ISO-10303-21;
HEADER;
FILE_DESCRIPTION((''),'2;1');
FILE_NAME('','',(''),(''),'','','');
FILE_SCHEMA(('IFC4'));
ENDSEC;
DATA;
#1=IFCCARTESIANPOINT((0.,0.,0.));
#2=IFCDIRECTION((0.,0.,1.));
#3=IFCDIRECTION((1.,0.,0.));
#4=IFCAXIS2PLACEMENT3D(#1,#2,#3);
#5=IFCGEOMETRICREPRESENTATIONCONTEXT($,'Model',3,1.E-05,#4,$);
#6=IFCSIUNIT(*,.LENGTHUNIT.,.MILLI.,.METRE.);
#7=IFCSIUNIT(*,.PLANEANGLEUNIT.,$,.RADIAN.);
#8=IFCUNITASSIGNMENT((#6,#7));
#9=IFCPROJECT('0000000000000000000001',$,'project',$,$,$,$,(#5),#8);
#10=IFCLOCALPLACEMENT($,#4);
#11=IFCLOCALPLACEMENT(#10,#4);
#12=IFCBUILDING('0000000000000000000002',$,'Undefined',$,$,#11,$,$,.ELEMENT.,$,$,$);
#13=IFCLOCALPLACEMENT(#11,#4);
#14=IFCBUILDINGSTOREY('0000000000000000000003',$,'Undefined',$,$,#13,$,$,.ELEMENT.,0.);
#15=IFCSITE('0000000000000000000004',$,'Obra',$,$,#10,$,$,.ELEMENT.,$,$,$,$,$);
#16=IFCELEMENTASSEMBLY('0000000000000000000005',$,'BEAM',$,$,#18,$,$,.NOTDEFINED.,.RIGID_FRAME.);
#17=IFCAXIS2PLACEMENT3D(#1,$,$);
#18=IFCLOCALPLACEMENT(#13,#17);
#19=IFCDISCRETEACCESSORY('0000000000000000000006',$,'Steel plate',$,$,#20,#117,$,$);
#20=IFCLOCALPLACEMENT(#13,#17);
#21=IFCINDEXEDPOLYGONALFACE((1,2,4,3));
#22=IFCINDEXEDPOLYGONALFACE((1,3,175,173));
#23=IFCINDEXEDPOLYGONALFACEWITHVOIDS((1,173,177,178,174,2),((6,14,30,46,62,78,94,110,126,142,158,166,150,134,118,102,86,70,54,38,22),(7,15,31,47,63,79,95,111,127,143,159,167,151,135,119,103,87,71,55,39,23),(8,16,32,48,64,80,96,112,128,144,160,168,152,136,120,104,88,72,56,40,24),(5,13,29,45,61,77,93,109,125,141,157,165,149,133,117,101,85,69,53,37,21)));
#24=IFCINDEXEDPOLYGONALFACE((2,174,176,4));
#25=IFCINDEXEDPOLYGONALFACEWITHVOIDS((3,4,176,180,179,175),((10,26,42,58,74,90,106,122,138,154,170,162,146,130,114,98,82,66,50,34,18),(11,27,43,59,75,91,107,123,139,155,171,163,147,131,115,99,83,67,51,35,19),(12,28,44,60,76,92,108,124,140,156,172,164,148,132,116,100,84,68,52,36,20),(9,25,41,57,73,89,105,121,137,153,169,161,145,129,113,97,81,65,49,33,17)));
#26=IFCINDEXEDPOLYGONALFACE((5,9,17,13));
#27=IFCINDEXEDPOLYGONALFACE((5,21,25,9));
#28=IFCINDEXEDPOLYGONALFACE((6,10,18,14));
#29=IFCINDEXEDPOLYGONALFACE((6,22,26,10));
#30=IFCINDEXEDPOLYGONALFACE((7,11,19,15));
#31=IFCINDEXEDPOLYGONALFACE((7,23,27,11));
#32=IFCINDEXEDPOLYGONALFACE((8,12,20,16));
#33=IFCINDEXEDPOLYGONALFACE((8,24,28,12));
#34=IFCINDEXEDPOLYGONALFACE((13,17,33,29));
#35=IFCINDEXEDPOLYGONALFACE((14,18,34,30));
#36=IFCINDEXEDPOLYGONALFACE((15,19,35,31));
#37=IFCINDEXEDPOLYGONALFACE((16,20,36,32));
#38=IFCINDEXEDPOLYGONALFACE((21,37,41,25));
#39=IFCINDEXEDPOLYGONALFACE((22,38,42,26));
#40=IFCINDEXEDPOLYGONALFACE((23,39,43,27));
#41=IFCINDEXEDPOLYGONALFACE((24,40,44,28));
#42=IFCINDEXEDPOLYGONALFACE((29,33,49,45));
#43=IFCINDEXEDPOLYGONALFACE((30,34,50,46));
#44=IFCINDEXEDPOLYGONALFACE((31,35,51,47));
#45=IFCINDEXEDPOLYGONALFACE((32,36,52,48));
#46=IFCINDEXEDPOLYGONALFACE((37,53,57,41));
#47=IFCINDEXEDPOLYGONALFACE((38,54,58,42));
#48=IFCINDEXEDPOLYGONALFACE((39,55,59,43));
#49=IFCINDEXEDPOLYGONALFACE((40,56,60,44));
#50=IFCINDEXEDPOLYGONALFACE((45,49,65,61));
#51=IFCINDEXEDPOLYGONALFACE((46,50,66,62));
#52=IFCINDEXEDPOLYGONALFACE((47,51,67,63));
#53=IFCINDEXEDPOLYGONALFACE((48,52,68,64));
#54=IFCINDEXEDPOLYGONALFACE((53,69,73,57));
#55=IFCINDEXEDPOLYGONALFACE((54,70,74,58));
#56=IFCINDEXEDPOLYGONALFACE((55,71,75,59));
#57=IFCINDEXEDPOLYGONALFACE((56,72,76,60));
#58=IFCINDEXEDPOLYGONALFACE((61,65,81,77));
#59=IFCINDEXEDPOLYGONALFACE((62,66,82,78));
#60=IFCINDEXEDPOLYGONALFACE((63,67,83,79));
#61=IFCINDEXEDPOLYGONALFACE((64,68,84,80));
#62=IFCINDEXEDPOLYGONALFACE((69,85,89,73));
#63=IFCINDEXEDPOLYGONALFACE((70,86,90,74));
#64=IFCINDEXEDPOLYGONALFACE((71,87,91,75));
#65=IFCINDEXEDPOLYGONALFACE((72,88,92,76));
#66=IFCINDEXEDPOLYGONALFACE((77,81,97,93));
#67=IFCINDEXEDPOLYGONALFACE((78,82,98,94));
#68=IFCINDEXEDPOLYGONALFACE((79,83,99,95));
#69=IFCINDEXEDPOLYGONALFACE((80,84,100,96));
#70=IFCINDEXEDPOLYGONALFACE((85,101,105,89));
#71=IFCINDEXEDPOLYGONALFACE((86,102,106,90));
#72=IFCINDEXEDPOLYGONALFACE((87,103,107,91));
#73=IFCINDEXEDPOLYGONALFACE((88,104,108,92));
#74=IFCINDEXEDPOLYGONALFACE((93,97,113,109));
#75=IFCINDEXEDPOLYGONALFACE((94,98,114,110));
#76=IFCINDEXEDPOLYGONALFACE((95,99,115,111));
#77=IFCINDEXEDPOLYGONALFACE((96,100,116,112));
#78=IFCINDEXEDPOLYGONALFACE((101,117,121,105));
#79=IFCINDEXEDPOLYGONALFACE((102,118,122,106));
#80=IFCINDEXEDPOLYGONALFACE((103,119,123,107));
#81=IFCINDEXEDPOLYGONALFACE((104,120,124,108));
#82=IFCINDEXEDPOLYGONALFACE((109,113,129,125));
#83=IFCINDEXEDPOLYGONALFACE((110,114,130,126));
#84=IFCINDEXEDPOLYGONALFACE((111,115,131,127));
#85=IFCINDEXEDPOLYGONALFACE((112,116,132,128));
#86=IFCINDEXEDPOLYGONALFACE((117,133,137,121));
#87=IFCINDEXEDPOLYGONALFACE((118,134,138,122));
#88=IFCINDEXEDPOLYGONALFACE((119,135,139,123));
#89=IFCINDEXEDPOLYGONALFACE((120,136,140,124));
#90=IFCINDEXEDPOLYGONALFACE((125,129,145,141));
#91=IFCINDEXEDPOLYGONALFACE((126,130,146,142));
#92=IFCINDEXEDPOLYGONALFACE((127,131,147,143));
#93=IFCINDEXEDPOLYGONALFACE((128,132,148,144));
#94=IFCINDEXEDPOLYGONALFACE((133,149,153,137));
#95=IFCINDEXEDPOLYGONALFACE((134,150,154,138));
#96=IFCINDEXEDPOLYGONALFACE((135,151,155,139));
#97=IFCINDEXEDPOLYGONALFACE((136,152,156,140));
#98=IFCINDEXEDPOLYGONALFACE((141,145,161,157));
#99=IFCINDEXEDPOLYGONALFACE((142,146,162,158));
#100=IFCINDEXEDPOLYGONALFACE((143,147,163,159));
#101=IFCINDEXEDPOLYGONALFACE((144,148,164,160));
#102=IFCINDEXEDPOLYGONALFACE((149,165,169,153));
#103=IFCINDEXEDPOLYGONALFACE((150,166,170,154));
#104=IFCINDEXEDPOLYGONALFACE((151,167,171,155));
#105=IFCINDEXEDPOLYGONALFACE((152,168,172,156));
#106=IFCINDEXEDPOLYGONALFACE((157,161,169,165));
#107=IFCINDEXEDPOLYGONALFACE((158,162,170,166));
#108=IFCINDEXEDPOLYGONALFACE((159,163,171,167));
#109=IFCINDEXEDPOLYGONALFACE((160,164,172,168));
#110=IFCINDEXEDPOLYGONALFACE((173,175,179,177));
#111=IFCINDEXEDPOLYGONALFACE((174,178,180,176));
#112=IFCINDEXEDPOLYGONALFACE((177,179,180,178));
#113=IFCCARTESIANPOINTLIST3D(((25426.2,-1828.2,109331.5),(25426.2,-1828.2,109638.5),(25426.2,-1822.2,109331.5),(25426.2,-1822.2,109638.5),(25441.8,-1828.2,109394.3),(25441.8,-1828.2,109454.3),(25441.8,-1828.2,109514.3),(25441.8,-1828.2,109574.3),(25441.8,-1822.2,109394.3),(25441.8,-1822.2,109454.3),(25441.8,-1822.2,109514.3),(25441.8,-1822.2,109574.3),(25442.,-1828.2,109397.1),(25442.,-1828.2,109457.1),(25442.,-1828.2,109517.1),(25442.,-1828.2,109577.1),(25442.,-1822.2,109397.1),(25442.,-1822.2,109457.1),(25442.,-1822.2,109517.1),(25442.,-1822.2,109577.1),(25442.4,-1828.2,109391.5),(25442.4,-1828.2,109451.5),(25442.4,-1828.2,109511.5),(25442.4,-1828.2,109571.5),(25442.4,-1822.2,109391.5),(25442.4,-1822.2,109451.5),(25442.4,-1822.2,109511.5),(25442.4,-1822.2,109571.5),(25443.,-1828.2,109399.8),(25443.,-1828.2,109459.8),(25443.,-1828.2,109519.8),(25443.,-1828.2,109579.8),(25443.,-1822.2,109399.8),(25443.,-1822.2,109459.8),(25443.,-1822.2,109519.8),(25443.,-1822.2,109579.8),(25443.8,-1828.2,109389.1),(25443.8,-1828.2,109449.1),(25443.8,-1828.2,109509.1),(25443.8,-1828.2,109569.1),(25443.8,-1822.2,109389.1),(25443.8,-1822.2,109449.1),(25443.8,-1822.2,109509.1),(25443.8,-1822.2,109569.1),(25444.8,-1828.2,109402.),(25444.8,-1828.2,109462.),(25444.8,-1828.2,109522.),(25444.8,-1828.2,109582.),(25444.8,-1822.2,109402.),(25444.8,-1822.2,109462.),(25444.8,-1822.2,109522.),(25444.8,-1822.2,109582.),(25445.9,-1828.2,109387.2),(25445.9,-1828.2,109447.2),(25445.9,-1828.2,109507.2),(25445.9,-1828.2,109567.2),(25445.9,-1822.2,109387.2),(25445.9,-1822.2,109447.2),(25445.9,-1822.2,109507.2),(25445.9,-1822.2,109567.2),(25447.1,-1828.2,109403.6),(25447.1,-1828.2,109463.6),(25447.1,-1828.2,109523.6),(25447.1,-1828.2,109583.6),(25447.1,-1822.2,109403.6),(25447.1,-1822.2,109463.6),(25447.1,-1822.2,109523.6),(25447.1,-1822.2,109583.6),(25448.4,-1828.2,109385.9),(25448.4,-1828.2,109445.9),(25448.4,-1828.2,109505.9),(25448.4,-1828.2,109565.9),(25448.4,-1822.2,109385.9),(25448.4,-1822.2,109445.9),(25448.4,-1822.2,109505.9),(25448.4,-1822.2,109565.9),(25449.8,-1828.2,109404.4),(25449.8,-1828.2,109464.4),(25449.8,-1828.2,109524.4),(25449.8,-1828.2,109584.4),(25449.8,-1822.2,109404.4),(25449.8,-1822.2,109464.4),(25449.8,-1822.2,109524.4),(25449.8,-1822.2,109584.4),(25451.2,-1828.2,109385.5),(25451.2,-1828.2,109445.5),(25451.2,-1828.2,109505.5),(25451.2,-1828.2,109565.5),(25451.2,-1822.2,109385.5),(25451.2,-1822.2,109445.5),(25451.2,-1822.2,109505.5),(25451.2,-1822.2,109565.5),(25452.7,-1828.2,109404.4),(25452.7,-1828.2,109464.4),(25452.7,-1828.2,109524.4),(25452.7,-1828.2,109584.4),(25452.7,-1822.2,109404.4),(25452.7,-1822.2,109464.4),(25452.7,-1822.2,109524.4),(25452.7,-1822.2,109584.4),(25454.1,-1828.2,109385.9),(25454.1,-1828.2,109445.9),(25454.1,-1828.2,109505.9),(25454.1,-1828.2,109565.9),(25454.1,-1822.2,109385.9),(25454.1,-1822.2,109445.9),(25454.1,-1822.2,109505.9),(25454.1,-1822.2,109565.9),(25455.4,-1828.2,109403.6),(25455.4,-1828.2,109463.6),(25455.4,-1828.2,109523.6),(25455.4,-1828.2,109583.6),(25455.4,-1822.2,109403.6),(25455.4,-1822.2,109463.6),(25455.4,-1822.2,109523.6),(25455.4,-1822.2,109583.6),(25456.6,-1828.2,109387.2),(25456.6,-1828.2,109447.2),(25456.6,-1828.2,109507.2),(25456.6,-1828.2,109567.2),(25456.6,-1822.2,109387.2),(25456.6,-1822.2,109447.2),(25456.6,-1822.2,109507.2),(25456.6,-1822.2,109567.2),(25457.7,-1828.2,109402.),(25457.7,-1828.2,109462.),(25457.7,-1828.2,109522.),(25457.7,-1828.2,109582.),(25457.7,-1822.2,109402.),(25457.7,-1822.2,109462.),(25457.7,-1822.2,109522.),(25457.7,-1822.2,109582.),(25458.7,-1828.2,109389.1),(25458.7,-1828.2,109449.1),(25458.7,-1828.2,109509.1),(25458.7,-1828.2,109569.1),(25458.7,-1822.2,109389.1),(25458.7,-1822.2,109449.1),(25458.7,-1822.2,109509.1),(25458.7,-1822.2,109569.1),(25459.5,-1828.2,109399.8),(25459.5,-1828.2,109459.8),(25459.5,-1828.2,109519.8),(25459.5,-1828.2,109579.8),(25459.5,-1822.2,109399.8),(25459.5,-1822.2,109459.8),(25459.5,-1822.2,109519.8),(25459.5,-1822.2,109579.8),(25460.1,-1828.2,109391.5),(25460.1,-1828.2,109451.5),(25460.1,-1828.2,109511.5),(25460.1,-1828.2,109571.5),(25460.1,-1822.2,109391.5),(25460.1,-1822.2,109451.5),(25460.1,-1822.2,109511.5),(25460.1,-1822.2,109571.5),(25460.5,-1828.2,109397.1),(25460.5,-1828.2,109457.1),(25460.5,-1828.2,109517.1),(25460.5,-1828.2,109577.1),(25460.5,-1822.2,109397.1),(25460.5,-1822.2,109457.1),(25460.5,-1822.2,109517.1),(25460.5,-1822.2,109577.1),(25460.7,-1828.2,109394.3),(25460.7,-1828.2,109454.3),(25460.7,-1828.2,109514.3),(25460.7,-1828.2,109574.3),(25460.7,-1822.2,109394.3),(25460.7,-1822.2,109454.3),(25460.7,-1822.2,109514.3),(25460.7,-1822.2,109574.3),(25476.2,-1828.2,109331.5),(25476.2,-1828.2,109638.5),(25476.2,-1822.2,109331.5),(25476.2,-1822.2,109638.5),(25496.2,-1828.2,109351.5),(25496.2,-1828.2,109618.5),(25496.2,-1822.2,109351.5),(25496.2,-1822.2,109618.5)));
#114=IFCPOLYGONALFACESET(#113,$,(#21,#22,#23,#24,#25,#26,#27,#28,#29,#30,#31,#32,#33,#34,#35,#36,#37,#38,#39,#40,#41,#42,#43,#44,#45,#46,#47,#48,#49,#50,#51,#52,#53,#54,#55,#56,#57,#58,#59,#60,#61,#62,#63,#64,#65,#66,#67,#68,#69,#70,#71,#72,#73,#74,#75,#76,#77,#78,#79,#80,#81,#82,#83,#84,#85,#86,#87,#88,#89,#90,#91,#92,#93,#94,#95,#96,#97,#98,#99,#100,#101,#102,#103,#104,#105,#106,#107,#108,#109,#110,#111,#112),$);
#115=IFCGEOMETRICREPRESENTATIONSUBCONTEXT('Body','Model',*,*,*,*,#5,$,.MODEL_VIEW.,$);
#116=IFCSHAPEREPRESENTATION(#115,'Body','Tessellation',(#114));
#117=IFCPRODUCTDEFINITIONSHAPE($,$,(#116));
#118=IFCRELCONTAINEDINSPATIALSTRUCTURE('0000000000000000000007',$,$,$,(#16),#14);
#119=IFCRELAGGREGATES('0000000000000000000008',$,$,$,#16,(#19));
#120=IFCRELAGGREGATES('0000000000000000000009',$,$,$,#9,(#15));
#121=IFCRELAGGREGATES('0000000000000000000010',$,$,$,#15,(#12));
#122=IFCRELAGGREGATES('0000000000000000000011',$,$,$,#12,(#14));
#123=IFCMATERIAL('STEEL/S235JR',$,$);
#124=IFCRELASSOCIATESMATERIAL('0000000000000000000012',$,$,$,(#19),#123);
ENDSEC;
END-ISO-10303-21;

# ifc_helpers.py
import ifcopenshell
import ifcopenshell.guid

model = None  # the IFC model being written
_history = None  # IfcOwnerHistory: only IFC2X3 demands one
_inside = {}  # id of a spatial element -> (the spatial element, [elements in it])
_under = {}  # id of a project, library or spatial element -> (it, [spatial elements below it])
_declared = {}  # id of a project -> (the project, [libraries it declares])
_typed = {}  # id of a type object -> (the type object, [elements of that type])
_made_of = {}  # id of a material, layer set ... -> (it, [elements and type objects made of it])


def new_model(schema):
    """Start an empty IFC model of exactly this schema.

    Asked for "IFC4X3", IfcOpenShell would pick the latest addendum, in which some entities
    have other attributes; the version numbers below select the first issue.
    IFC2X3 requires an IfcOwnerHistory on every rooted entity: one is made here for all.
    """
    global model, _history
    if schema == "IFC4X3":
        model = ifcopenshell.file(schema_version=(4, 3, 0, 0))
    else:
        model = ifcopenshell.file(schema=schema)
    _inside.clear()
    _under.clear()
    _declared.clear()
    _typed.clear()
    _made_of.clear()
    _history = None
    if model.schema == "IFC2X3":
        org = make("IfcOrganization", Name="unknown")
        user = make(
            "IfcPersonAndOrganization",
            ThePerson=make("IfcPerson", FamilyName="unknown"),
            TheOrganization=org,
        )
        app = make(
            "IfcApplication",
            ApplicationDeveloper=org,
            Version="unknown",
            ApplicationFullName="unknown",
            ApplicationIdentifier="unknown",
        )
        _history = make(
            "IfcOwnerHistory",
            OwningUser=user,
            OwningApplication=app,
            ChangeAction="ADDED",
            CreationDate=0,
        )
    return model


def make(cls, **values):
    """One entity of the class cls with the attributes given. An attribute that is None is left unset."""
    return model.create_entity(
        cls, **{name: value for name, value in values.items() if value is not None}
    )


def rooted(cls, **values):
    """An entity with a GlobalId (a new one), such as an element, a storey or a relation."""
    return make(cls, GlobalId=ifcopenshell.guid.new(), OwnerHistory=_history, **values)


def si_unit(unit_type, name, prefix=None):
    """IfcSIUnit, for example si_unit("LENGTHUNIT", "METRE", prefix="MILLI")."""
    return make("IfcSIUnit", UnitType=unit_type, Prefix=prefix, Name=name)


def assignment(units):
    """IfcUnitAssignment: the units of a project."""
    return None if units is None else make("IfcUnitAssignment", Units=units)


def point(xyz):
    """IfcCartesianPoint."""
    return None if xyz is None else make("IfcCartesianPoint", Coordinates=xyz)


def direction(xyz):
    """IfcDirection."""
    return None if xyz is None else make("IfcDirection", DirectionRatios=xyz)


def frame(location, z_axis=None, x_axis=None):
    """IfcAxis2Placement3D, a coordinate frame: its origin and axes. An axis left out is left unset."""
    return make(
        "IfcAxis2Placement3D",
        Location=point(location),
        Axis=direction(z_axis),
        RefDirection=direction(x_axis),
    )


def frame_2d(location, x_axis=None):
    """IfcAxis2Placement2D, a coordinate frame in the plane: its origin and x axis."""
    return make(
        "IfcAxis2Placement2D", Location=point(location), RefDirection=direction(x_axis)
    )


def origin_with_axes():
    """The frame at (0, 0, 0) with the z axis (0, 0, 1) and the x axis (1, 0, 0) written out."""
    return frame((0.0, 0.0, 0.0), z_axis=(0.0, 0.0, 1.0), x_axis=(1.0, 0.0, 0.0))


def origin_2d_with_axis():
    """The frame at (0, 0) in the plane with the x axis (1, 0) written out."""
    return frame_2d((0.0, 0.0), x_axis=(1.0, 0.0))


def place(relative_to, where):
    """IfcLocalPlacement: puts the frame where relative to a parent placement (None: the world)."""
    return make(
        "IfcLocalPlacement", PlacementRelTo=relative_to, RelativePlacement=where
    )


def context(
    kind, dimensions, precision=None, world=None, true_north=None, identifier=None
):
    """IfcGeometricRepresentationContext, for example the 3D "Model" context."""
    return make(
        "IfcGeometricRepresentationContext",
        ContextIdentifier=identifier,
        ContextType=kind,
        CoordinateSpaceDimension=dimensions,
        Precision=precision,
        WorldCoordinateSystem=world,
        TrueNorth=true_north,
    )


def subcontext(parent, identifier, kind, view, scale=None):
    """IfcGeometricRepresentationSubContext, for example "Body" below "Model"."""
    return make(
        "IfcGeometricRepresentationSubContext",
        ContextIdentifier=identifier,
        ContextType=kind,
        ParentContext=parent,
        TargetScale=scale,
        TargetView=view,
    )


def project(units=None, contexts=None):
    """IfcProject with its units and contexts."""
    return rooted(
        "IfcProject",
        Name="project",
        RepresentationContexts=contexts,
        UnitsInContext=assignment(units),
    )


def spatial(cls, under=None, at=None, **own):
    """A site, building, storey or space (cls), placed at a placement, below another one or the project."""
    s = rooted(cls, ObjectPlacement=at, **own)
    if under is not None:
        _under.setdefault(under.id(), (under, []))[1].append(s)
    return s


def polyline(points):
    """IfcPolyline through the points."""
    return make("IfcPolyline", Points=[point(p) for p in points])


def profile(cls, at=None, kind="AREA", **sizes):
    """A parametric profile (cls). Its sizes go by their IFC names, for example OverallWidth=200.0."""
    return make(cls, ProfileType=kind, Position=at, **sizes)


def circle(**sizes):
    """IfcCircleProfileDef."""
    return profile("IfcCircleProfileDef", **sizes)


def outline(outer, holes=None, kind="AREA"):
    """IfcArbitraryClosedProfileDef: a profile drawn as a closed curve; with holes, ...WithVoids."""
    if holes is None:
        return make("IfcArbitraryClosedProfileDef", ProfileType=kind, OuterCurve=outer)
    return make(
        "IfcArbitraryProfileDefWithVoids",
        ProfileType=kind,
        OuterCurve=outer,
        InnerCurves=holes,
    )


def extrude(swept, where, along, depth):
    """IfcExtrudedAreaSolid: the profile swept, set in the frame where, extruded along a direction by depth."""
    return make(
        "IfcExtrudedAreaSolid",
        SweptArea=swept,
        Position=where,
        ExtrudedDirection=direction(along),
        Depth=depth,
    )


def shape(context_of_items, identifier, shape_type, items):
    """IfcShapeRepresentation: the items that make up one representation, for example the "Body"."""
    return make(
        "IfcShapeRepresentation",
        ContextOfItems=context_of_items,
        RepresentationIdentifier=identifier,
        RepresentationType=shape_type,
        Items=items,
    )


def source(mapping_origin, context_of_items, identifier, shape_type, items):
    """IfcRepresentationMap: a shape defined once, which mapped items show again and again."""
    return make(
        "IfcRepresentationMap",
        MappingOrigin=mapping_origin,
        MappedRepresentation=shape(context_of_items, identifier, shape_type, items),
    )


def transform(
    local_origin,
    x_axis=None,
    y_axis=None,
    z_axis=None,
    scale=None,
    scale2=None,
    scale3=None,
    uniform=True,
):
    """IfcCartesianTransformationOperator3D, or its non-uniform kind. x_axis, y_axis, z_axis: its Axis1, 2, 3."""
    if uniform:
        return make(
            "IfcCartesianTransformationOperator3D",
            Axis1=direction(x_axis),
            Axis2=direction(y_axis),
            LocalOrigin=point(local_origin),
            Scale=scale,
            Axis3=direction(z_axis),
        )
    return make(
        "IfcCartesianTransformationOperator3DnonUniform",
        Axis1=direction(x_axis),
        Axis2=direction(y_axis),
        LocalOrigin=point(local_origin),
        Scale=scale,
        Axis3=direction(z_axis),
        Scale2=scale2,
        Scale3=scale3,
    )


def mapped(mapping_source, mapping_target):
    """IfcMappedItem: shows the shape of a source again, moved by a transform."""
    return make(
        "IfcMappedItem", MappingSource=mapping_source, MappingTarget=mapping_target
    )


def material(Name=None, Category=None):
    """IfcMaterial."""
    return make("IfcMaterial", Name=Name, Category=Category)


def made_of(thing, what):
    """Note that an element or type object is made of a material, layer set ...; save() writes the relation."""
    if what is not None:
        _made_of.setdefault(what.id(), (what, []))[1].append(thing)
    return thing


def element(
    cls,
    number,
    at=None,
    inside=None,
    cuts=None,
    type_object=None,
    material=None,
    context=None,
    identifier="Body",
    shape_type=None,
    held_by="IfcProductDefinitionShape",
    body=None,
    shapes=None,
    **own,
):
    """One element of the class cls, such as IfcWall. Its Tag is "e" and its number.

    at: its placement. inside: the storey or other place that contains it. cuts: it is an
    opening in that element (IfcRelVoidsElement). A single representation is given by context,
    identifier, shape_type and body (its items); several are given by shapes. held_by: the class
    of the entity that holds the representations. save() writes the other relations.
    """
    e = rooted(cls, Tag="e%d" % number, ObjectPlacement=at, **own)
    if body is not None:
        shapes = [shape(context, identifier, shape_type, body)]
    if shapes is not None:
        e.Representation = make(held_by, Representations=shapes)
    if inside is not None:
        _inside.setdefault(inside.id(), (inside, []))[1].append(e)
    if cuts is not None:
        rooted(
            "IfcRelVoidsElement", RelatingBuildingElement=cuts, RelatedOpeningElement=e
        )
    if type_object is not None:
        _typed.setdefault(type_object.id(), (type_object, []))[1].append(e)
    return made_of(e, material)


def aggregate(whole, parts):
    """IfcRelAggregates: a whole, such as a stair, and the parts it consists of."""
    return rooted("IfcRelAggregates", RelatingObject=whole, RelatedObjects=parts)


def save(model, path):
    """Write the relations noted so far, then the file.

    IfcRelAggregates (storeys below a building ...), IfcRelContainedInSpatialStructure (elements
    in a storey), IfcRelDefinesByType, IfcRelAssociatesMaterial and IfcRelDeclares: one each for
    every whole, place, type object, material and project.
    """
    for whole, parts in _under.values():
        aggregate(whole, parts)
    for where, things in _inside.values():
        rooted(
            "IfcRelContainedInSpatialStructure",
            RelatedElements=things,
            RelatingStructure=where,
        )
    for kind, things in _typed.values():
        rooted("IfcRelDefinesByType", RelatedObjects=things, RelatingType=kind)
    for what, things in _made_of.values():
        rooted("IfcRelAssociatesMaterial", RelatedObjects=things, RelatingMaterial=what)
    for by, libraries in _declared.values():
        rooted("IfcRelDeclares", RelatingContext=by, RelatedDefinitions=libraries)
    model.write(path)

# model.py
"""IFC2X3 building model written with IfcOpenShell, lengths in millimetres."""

from ifc_helpers import new_model, si_unit, frame, origin_with_axes, origin_2d_with_axis, place, context, subcontext, project, spatial, polyline, circle, outline, extrude, source, transform, mapped, material, element, aggregate, save


model = new_model("IFC2X3")

# Units and contexts
model_context = context("Model", 3, precision=1e-05, world=origin_with_axes())
body_context = subcontext(model_context, "Body", "Model", "MODEL_VIEW")
ifc_project = project(units=[si_unit("LENGTHUNIT", "METRE", prefix="MILLI"), si_unit("PLANEANGLEUNIT", "RADIAN")], contexts=[model_context])

# Site, building, storey
site_placement = place(None, origin_with_axes())
site = spatial("IfcSite", under=ifc_project, at=site_placement, Name="Obra", CompositionType="ELEMENT")
building_placement = place(site_placement, origin_with_axes())
building = spatial("IfcBuilding", under=site, at=building_placement, Name="Undefined", CompositionType="ELEMENT")
storey_placement = place(building_placement, origin_with_axes())
storey = spatial("IfcBuildingStorey", under=building, at=storey_placement, Name="Undefined", CompositionType="ELEMENT", Elevation=0.0)

# Shared definitions
ifc_material = material(Name="STEEL/S235JR")
shared_shape = source(origin_with_axes(), body_context, "Body", "SweptSolid", [
    extrude(circle(Radius=9.5, at=origin_2d_with_axis()), frame((0.0, -9.8, 0.0), z_axis=(0.0, 1.0, 0.0), x_axis=(1.0, 0.0, 0.0)), (0.0, 0.0, 1.0), 6.2),
])

# Element assembly, discrete accessory, opening
assembly_1_placement = place(storey_placement, origin_with_axes())
assembly_1 = element("IfcElementAssembly", 1, at=assembly_1_placement, inside=storey, Name="BEAM", AssemblyPlace="NOTDEFINED", PredefinedType="RIGID_FRAME")
discrete_accessory_1_placement = place(assembly_1_placement, frame((25426.2, -1825.2, 109331.5), z_axis=(0.0, -1.0, 0.0), x_axis=(1.0, 0.0, 0.0)))
discrete_accessory_1 = element("IfcDiscreteAccessory", 2, at=discrete_accessory_1_placement, material=ifc_material, Name="Steel plate", context=body_context, shape_type="SweptSolid", body=[
    extrude(outline(polyline([(0.0, 0.0), (50.0, 0.0), (70.0, 20.0), (70.0, 287.0), (50.0, 307.0), (0.0, 307.0), (0.0, 0.0)])), frame((0.0, 0.0, -3.0), z_axis=(0.0, 0.0, 1.0), x_axis=(1.0, 0.0, 0.0)), (0.0, 0.0, 1.0), 6.0),
])
opening_1_placement = place(assembly_1_placement, frame((25486.2, -1832.0, 109650.0), z_axis=(-1.0, 0.0, 0.0), x_axis=(0.0, 0.0, -1.0)))
element("IfcOpeningElement", 3, at=opening_1_placement, cuts=discrete_accessory_1, ObjectType="Opening", context=body_context, shape_type="MappedRepresentation", body=[
    mapped(shared_shape, transform((75.0, 0.0, 35.0))),
    mapped(shared_shape, transform((135.0, 0.0, 35.0))),
    mapped(shared_shape, transform((195.0, 0.0, 35.0))),
    mapped(shared_shape, transform((255.0, 0.0, 35.0))),
])
aggregate(assembly_1, [discrete_accessory_1])

save(model, "model.ifc")
